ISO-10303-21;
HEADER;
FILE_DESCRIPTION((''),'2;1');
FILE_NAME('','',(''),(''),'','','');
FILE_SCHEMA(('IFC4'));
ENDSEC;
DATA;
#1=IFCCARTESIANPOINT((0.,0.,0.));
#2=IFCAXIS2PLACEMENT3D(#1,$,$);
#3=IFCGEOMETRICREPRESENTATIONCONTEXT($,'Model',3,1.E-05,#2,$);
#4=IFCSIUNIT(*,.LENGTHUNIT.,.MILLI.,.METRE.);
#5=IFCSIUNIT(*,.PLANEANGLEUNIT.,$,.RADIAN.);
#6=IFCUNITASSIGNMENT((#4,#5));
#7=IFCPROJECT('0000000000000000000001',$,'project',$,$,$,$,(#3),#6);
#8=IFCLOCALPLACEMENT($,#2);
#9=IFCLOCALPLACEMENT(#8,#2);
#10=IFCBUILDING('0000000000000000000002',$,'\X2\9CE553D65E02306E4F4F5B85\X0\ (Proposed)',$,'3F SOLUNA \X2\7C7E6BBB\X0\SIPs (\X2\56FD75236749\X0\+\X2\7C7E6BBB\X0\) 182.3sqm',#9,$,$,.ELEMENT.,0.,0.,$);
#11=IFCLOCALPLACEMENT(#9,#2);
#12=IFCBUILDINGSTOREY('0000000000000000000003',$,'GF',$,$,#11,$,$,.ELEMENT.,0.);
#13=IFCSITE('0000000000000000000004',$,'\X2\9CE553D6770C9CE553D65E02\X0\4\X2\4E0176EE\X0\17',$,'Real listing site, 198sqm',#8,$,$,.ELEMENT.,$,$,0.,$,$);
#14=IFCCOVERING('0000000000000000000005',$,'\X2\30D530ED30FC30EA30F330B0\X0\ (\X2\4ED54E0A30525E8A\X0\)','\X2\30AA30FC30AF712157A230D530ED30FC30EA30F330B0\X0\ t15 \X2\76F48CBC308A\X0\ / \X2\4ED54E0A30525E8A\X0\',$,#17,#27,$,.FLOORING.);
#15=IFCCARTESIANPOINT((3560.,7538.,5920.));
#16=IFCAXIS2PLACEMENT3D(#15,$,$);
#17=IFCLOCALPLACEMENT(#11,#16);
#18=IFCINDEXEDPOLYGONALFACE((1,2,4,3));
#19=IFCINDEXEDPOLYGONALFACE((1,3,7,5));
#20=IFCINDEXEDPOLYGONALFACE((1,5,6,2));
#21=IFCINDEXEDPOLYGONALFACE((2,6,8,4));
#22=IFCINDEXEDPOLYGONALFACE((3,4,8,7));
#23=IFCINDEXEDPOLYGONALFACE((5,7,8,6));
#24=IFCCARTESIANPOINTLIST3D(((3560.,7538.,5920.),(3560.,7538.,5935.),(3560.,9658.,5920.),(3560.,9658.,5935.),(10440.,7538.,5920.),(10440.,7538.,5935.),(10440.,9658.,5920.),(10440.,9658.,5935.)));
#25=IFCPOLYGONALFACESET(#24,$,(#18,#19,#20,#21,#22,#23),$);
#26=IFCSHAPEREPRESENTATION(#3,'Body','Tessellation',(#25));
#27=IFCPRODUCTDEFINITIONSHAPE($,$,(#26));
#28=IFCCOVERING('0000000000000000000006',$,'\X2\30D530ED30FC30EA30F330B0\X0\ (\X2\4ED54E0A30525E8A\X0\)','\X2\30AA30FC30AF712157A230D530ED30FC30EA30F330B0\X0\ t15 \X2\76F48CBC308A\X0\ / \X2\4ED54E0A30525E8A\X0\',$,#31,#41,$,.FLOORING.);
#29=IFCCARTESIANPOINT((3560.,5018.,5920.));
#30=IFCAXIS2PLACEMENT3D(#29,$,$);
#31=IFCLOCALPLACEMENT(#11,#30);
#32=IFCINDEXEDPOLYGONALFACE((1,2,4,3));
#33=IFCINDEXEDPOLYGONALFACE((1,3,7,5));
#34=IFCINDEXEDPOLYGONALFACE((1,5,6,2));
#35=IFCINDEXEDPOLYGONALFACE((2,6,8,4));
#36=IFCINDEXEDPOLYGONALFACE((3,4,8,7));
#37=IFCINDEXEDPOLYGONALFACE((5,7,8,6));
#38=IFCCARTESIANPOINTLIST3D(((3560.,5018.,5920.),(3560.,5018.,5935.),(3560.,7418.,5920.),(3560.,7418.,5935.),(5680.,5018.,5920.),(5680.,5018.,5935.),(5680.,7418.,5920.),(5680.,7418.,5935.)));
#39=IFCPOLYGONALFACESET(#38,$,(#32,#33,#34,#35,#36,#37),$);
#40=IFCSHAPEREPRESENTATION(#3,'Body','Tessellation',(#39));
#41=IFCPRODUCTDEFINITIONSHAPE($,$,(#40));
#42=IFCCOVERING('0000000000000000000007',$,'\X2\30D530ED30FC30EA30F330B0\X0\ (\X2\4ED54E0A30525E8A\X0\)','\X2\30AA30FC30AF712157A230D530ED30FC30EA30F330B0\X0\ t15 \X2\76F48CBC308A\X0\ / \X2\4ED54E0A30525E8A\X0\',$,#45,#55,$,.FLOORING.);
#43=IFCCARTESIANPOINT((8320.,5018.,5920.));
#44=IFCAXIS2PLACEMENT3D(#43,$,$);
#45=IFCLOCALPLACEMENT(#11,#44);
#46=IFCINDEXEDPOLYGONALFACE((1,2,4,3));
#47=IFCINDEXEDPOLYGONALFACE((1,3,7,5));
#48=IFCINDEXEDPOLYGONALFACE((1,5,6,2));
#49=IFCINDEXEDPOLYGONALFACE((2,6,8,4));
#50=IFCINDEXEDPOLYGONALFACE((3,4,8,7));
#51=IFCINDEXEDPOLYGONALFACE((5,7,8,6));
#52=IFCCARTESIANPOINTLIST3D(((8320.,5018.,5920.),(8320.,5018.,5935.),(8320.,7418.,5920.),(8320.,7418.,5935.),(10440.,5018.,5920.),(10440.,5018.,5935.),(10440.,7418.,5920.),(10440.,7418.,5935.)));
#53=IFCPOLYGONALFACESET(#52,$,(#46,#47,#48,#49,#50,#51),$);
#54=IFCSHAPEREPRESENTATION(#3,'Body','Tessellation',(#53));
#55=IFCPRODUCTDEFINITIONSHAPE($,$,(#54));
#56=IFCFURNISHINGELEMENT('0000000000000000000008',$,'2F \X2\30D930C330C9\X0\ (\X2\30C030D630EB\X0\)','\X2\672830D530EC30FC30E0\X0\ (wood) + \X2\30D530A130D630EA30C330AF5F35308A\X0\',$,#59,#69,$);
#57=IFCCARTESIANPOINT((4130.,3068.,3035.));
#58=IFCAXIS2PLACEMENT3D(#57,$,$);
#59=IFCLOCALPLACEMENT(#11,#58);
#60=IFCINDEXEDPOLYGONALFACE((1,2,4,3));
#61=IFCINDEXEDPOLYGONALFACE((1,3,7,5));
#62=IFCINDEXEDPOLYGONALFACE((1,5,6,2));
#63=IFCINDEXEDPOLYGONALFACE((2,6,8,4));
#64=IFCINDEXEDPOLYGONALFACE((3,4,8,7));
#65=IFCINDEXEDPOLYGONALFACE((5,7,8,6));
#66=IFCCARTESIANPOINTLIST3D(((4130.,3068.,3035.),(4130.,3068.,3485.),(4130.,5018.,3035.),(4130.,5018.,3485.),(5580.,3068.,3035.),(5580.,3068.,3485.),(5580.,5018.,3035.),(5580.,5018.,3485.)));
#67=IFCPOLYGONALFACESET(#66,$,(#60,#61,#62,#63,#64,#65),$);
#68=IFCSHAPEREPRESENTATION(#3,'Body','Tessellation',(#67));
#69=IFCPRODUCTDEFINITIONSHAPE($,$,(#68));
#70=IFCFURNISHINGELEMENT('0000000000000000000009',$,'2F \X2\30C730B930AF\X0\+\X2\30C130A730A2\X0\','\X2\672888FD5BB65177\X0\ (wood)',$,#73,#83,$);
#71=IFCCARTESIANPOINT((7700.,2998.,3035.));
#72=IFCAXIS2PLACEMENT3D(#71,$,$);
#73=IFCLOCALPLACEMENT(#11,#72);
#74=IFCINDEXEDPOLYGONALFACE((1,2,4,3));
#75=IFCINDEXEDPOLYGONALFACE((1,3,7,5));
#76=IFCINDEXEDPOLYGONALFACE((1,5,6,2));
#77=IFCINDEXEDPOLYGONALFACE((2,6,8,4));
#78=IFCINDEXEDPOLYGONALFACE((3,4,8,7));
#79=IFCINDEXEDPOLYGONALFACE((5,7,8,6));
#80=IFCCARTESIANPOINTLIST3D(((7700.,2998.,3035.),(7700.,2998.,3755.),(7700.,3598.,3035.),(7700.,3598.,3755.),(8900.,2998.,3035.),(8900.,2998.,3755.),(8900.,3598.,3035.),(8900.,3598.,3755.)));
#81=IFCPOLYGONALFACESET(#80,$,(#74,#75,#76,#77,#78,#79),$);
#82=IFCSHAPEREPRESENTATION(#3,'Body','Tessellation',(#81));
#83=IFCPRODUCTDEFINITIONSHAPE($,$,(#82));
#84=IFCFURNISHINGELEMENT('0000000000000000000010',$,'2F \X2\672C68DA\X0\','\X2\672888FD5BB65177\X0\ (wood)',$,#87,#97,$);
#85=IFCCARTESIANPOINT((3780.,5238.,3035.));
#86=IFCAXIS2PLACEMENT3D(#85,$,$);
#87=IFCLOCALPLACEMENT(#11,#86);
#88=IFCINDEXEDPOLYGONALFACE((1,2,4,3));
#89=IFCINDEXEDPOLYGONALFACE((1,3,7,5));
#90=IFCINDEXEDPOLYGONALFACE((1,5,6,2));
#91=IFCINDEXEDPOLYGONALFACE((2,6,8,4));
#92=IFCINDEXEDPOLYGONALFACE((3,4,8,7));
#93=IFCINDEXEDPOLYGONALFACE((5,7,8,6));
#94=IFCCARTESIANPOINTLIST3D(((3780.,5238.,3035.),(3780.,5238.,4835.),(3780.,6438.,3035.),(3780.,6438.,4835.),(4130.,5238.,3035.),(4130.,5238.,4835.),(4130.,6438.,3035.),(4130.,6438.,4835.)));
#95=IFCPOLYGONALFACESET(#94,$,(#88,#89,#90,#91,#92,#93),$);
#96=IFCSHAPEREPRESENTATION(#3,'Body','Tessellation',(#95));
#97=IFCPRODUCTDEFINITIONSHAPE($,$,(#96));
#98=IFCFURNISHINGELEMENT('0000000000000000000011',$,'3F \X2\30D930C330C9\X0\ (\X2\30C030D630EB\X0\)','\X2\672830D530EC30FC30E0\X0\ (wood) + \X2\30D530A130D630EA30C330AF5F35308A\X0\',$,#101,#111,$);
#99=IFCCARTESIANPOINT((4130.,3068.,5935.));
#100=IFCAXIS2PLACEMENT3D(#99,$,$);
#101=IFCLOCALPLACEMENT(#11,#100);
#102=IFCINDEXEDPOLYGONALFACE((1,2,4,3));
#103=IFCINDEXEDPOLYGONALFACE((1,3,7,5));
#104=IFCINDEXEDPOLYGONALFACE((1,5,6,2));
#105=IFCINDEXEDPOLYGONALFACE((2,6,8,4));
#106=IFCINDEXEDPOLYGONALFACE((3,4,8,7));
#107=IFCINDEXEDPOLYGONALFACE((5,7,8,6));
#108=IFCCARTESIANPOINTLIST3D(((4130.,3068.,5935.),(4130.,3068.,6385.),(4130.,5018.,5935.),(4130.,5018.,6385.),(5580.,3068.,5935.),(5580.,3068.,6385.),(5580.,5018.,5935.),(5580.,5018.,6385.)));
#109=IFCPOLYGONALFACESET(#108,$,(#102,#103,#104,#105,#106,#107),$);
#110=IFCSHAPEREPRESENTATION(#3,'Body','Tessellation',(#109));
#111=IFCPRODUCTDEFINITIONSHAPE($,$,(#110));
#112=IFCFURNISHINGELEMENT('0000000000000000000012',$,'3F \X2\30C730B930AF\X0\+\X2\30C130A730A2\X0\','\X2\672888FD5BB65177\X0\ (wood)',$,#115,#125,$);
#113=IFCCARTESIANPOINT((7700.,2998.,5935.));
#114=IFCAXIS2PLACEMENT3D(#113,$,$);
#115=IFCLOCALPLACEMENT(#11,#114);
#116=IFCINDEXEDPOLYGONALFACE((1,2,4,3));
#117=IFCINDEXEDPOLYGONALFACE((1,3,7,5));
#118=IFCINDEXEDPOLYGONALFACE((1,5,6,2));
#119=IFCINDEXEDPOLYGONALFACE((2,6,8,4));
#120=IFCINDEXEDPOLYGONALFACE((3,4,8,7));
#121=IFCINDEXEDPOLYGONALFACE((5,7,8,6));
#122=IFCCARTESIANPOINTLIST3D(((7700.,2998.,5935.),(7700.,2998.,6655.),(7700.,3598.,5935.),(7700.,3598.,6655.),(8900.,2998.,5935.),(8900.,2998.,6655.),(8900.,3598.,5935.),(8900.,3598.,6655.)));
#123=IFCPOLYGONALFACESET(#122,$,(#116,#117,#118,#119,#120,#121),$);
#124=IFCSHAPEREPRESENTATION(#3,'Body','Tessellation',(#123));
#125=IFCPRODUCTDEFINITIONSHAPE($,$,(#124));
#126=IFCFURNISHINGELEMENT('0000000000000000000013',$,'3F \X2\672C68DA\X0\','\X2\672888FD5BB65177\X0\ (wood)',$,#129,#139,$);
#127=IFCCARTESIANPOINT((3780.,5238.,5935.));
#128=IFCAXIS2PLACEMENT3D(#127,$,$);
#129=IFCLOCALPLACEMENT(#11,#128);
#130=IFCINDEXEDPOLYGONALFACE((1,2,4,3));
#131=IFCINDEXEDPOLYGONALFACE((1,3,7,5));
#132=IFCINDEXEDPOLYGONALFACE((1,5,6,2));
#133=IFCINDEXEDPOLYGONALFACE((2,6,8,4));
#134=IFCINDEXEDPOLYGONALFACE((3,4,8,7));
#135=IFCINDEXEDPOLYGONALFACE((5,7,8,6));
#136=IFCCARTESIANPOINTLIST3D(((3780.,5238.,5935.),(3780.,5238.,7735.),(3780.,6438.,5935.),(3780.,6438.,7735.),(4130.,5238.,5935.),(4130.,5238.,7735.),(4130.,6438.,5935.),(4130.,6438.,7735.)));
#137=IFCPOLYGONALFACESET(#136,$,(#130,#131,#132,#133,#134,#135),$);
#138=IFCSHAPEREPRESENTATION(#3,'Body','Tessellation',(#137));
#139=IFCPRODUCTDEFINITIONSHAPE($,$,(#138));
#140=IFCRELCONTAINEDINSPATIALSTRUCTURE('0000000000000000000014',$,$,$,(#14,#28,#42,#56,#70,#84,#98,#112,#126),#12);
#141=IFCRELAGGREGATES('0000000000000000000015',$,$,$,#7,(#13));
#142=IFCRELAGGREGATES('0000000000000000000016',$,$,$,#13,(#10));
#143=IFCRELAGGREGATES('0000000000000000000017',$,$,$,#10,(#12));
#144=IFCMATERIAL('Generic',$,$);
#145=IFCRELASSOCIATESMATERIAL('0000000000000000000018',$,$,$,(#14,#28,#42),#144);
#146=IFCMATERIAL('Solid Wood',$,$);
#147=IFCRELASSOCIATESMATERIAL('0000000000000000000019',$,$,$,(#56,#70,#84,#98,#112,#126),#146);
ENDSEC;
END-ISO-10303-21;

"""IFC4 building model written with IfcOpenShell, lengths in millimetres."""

from ifc_helpers import new_model, si_unit, frame, frame_2d, origin, place, context, project, spatial, rectangle, extrude, material, element, save


model = new_model("IFC4")

# Units and contexts
model_context = context("Model", 3, precision=1e-05, world=origin())
ifc_project = project(units=[si_unit("LENGTHUNIT", "METRE", prefix="MILLI"), si_unit("PLANEANGLEUNIT", "RADIAN")], contexts=[model_context])

# Site, building, storey
site_placement = place(None, origin())
site = spatial("IfcSite", under=ifc_project, at=site_placement, Name="鳥取県鳥取市4丁目17", ObjectType="Real listing site, 198sqm", CompositionType="ELEMENT", RefElevation=0.0)
building_placement = place(site_placement, origin())
building = spatial("IfcBuilding", under=site, at=building_placement, Name="鳥取市の住宅 (Proposed)", ObjectType="3F SOLUNA 籾殻SIPs (国産杉+籾殻) 182.3sqm", CompositionType="ELEMENT", ElevationOfRefHeight=0.0, ElevationOfTerrain=0.0)
storey_placement = place(building_placement, origin())
storey = spatial("IfcBuildingStorey", under=building, at=storey_placement, Name="GF", CompositionType="ELEMENT", Elevation=0.0)

# Shared definitions
ifc_material_1 = material(Name="Solid Wood")

# Shared definitions
ifc_material_2 = material(Name="Generic")

# Coverings
covering_1_placement = place(storey_placement, frame((3560.0, 7538.0, 5920.0)))
element("IfcCovering", 1, at=covering_1_placement, inside=storey, material=ifc_material_2, Name="フローリング (仕上げ床)", Description="オーク無垢フローリング t15 直貼り / 仕上げ床", PredefinedType="FLOORING", context=model_context, shape_type="SweptSolid", body=[
    extrude(rectangle(XDim=6880.0, YDim=2120.0, at=frame_2d((3440.0, 1060.0))), frame((3560.0, 7538.0, 5920.0)), (0.0, 0.0, 1.0), 15.0),
])
covering_2_placement = place(storey_placement, frame((3560.0, 5018.0, 5920.0)))
element("IfcCovering", 2, at=covering_2_placement, inside=storey, material=ifc_material_2, Name="フローリング (仕上げ床)", Description="オーク無垢フローリング t15 直貼り / 仕上げ床", PredefinedType="FLOORING", context=model_context, shape_type="SweptSolid", body=[
    extrude(rectangle(XDim=2120.0, YDim=2400.0, at=frame_2d((1060.0, 1200.0))), frame((3560.0, 5018.0, 5920.0)), (0.0, 0.0, 1.0), 15.0),
])
covering_3_placement = place(storey_placement, frame((8320.0, 5018.0, 5920.0)))
element("IfcCovering", 3, at=covering_3_placement, inside=storey, material=ifc_material_2, Name="フローリング (仕上げ床)", Description="オーク無垢フローリング t15 直貼り / 仕上げ床", PredefinedType="FLOORING", context=model_context, shape_type="SweptSolid", body=[
    extrude(rectangle(XDim=2120.0, YDim=2400.0, at=frame_2d((1060.0, 1200.0))), frame((8320.0, 5018.0, 5920.0)), (0.0, 0.0, 1.0), 15.0),
])

# Furnishing elements
furnishing_1_placement = place(storey_placement, frame((4130.0, 3068.0, 3035.0)))
element("IfcFurnishingElement", 4, at=furnishing_1_placement, inside=storey, material=ifc_material_1, Name="2F ベッド (ダブル)", Description="木フレーム (wood) + ファブリック張り", context=model_context, shape_type="SweptSolid", body=[
    extrude(rectangle(XDim=1450.0, YDim=1950.0, at=frame_2d((725.0, 975.0))), frame((4130.0, 3068.0, 3035.0)), (0.0, 0.0, 1.0), 450.0),
])
furnishing_2_placement = place(storey_placement, frame((7700.0, 2998.0, 3035.0)))
element("IfcFurnishingElement", 5, at=furnishing_2_placement, inside=storey, material=ifc_material_1, Name="2F デスク+チェア", Description="木製家具 (wood)", context=model_context, shape_type="SweptSolid", body=[
    extrude(rectangle(XDim=1200.0, YDim=600.0, at=frame_2d((600.0, 300.0))), frame((7700.0, 2998.0, 3035.0)), (0.0, 0.0, 1.0), 720.0),
])
furnishing_3_placement = place(storey_placement, frame((3780.0, 5238.0, 3035.0)))
element("IfcFurnishingElement", 6, at=furnishing_3_placement, inside=storey, material=ifc_material_1, Name="2F 本棚", Description="木製家具 (wood)", context=model_context, shape_type="SweptSolid", body=[
    extrude(rectangle(XDim=350.0, YDim=1200.0, at=frame_2d((175.0, 600.0))), frame((3780.0, 5238.0, 3035.0)), (0.0, 0.0, 1.0), 1800.0),
])
furnishing_4_placement = place(storey_placement, frame((4130.0, 3068.0, 5935.0)))
element("IfcFurnishingElement", 7, at=furnishing_4_placement, inside=storey, material=ifc_material_1, Name="3F ベッド (ダブル)", Description="木フレーム (wood) + ファブリック張り", context=model_context, shape_type="SweptSolid", body=[
    extrude(rectangle(XDim=1450.0, YDim=1950.0, at=frame_2d((725.0, 975.0))), frame((4130.0, 3068.0, 5935.0)), (0.0, 0.0, 1.0), 450.0),
])
furnishing_5_placement = place(storey_placement, frame((7700.0, 2998.0, 5935.0)))
element("IfcFurnishingElement", 8, at=furnishing_5_placement, inside=storey, material=ifc_material_1, Name="3F デスク+チェア", Description="木製家具 (wood)", context=model_context, shape_type="SweptSolid", body=[
    extrude(rectangle(XDim=1200.0, YDim=600.0, at=frame_2d((600.0, 300.0))), frame((7700.0, 2998.0, 5935.0)), (0.0, 0.0, 1.0), 720.0),
])
furnishing_6_placement = place(storey_placement, frame((3780.0, 5238.0, 5935.0)))
element("IfcFurnishingElement", 9, at=furnishing_6_placement, inside=storey, material=ifc_material_1, Name="3F 本棚", Description="木製家具 (wood)", context=model_context, shape_type="SweptSolid", body=[
    extrude(rectangle(XDim=350.0, YDim=1200.0, at=frame_2d((175.0, 600.0))), frame((3780.0, 5238.0, 5935.0)), (0.0, 0.0, 1.0), 1800.0),
])

save(model, "model.ifc")
